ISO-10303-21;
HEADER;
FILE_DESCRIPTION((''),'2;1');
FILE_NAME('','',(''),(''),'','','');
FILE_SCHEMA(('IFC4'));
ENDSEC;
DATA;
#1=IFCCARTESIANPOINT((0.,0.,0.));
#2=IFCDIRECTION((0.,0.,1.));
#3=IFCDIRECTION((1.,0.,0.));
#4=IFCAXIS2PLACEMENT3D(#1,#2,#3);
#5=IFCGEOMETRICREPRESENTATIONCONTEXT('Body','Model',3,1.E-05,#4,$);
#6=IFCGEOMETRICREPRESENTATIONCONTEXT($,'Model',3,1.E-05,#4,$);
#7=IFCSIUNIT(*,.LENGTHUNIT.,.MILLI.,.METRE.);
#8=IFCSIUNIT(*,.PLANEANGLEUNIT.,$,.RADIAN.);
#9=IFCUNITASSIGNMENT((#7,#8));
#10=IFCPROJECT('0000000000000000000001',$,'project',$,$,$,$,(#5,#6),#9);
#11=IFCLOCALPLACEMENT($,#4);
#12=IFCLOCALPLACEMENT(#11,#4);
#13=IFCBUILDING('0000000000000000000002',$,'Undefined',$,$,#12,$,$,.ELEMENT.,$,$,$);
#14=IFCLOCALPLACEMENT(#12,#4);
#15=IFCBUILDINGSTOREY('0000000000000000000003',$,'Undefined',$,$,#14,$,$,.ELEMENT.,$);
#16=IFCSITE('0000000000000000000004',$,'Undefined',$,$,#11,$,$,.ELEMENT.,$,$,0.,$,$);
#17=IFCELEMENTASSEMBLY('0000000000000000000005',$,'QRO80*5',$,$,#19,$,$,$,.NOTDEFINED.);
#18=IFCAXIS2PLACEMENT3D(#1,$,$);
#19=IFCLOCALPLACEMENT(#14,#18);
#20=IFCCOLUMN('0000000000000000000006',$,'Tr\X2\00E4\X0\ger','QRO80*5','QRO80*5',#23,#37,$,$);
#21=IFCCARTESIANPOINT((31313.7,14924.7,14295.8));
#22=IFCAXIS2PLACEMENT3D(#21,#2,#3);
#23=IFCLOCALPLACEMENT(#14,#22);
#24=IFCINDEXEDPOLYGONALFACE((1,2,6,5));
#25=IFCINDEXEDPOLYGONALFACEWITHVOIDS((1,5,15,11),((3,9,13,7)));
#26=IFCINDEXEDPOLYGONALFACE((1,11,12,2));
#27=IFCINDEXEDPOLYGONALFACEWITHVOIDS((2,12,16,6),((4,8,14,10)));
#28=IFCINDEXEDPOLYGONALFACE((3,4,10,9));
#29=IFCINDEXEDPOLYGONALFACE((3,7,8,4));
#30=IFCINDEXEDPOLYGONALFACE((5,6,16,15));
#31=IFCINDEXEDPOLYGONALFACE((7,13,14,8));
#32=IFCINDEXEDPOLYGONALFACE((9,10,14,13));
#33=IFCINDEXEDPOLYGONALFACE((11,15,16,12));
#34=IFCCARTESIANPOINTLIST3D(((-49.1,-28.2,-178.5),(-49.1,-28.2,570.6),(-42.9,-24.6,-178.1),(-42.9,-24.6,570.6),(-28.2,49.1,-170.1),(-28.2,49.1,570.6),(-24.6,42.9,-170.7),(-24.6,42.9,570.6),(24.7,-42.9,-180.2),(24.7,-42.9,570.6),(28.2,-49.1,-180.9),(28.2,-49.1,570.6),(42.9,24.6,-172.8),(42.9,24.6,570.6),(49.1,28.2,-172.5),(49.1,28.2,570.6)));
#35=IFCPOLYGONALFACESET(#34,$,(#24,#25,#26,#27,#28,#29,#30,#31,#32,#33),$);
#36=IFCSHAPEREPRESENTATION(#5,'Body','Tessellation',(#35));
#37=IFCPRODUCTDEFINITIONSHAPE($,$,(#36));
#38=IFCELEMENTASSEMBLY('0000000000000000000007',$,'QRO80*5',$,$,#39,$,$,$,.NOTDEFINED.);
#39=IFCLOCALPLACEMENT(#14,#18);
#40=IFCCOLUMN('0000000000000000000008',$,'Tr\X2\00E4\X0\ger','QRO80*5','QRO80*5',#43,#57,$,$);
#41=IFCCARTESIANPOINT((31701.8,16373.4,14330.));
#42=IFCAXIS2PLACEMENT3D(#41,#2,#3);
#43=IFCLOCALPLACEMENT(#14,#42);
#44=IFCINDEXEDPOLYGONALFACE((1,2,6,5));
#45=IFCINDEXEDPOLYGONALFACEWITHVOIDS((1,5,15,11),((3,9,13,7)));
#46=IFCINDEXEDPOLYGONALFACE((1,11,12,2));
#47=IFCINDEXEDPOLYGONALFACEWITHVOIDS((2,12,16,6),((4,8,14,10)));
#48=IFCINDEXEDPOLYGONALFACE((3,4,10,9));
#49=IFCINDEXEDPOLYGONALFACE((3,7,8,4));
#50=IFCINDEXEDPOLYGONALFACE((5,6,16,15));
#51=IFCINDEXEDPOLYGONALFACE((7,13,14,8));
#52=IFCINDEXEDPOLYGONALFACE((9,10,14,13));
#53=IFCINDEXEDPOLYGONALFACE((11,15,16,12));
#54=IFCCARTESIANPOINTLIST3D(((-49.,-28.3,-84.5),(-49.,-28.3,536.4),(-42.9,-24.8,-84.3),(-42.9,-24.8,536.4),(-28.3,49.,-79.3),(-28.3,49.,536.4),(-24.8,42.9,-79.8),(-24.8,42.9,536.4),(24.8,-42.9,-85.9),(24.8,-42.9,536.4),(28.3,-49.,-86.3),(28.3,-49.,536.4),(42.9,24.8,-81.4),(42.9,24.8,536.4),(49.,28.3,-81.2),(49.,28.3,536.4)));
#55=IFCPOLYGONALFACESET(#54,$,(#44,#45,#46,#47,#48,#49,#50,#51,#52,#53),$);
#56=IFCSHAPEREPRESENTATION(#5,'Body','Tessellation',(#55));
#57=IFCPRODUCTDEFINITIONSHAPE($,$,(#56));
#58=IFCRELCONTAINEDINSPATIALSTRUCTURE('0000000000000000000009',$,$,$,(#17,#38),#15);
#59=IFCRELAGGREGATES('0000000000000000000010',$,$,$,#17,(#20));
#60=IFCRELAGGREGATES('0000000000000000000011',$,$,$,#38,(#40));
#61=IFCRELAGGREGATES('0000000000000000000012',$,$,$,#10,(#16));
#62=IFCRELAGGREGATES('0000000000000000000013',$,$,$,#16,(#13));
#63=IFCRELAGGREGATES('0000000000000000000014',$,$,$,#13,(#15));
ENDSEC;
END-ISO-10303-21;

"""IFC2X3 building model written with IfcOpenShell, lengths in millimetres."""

from ifc_helpers import new_model, si_unit, frame, origin_with_axes, origin_2d_with_axis, place, context, project, spatial, hollow_rectangle, extrude, clip, halfspace, element, aggregate, save


model = new_model("IFC2X3")

# Units and contexts
model_context_1 = context("Model", 3, precision=1e-05, world=origin_with_axes(), identifier="Body")
model_context_2 = context("Model", 3, precision=1e-05, world=origin_with_axes())
ifc_project = project(units=[si_unit("LENGTHUNIT", "METRE", prefix="MILLI"), si_unit("PLANEANGLEUNIT", "RADIAN")], contexts=[model_context_1, model_context_2])

# Site, building, storey
site_placement = place(None, origin_with_axes())
site = spatial("IfcSite", under=ifc_project, at=site_placement, Name="Undefined", CompositionType="ELEMENT", RefElevation=0.0)
building_placement = place(site_placement, origin_with_axes())
building = spatial("IfcBuilding", under=site, at=building_placement, Name="Undefined", CompositionType="ELEMENT")
storey_placement = place(building_placement, origin_with_axes())
storey = spatial("IfcBuildingStorey", under=building, at=storey_placement, Name="Undefined", CompositionType="ELEMENT")

# Element assemblies, columns
assembly_1 = element("IfcElementAssembly", 1, inside=storey, Name="QRO80*5", PredefinedType="NOTDEFINED")
column_1_placement = place(storey_placement, frame((31313.7, 14924.7, 14295.8), z_axis=(0.0, 0.0, 1.0), x_axis=(1.0, 0.0, 0.0)))
column_1 = element("IfcColumn", 2, at=column_1_placement, Name="Träger", Description="QRO80*5", ObjectType="QRO80*5", context=model_context_1, shape_type="Clipping", body=[
    clip(clip(extrude(hollow_rectangle(XDim=80.0, YDim=80.0, WallThickness=5.0, at=origin_2d_with_axis()), frame((0.0, 0.0, 570.6), z_axis=(0.0, 0.0, -1.0), x_axis=(-0.261057, -0.965323, 0.0)), (0.0, 0.0, 1.0), 751.5), halfspace(frame((39.1, -2.5, -175.8), z_axis=(0.001304, -0.108856, 0.994057), x_axis=(-0.063857, -0.992038, -0.108551)), True)), halfspace(frame((38.6, -10.4, 570.6), z_axis=(-0.000017, 0.000005, -1.0), x_axis=(0.258815, 0.965927, 0.000003)), True)),
])
aggregate(assembly_1, [column_1])
assembly_2 = element("IfcElementAssembly", 3, inside=storey, Name="QRO80*5", PredefinedType="NOTDEFINED")
column_2_placement = place(storey_placement, frame((31701.8, 16373.4, 14330.0), z_axis=(0.0, 0.0, 1.0), x_axis=(1.0, 0.0, 0.0)))
column_2 = element("IfcColumn", 4, at=column_2_placement, Name="Träger", Description="QRO80*5", ObjectType="QRO80*5", context=model_context_1, shape_type="Clipping", body=[
    clip(clip(extrude(hollow_rectangle(XDim=80.0, YDim=80.0, WallThickness=5.0, at=origin_2d_with_axis()), frame((0.0, 0.0, 536.4), z_axis=(0.0, 0.0, -1.0), x_axis=(-0.258718, -0.965953, -0.000004)), (0.0, 0.0, 1.0), 622.7), halfspace(frame((39.3, -5.1, -83.4), z_axis=(0.005592, -0.067661, 0.997693), x_axis=(-0.128861, -0.989439, -0.066379)), True)), halfspace(frame((38.6, -10.4, 536.4), z_axis=(-0.000017, 0.000005, -1.0), x_axis=(0.258841, 0.96592, 0.0)), True)),
])
aggregate(assembly_2, [column_2])

save(model, "model.ifc")
